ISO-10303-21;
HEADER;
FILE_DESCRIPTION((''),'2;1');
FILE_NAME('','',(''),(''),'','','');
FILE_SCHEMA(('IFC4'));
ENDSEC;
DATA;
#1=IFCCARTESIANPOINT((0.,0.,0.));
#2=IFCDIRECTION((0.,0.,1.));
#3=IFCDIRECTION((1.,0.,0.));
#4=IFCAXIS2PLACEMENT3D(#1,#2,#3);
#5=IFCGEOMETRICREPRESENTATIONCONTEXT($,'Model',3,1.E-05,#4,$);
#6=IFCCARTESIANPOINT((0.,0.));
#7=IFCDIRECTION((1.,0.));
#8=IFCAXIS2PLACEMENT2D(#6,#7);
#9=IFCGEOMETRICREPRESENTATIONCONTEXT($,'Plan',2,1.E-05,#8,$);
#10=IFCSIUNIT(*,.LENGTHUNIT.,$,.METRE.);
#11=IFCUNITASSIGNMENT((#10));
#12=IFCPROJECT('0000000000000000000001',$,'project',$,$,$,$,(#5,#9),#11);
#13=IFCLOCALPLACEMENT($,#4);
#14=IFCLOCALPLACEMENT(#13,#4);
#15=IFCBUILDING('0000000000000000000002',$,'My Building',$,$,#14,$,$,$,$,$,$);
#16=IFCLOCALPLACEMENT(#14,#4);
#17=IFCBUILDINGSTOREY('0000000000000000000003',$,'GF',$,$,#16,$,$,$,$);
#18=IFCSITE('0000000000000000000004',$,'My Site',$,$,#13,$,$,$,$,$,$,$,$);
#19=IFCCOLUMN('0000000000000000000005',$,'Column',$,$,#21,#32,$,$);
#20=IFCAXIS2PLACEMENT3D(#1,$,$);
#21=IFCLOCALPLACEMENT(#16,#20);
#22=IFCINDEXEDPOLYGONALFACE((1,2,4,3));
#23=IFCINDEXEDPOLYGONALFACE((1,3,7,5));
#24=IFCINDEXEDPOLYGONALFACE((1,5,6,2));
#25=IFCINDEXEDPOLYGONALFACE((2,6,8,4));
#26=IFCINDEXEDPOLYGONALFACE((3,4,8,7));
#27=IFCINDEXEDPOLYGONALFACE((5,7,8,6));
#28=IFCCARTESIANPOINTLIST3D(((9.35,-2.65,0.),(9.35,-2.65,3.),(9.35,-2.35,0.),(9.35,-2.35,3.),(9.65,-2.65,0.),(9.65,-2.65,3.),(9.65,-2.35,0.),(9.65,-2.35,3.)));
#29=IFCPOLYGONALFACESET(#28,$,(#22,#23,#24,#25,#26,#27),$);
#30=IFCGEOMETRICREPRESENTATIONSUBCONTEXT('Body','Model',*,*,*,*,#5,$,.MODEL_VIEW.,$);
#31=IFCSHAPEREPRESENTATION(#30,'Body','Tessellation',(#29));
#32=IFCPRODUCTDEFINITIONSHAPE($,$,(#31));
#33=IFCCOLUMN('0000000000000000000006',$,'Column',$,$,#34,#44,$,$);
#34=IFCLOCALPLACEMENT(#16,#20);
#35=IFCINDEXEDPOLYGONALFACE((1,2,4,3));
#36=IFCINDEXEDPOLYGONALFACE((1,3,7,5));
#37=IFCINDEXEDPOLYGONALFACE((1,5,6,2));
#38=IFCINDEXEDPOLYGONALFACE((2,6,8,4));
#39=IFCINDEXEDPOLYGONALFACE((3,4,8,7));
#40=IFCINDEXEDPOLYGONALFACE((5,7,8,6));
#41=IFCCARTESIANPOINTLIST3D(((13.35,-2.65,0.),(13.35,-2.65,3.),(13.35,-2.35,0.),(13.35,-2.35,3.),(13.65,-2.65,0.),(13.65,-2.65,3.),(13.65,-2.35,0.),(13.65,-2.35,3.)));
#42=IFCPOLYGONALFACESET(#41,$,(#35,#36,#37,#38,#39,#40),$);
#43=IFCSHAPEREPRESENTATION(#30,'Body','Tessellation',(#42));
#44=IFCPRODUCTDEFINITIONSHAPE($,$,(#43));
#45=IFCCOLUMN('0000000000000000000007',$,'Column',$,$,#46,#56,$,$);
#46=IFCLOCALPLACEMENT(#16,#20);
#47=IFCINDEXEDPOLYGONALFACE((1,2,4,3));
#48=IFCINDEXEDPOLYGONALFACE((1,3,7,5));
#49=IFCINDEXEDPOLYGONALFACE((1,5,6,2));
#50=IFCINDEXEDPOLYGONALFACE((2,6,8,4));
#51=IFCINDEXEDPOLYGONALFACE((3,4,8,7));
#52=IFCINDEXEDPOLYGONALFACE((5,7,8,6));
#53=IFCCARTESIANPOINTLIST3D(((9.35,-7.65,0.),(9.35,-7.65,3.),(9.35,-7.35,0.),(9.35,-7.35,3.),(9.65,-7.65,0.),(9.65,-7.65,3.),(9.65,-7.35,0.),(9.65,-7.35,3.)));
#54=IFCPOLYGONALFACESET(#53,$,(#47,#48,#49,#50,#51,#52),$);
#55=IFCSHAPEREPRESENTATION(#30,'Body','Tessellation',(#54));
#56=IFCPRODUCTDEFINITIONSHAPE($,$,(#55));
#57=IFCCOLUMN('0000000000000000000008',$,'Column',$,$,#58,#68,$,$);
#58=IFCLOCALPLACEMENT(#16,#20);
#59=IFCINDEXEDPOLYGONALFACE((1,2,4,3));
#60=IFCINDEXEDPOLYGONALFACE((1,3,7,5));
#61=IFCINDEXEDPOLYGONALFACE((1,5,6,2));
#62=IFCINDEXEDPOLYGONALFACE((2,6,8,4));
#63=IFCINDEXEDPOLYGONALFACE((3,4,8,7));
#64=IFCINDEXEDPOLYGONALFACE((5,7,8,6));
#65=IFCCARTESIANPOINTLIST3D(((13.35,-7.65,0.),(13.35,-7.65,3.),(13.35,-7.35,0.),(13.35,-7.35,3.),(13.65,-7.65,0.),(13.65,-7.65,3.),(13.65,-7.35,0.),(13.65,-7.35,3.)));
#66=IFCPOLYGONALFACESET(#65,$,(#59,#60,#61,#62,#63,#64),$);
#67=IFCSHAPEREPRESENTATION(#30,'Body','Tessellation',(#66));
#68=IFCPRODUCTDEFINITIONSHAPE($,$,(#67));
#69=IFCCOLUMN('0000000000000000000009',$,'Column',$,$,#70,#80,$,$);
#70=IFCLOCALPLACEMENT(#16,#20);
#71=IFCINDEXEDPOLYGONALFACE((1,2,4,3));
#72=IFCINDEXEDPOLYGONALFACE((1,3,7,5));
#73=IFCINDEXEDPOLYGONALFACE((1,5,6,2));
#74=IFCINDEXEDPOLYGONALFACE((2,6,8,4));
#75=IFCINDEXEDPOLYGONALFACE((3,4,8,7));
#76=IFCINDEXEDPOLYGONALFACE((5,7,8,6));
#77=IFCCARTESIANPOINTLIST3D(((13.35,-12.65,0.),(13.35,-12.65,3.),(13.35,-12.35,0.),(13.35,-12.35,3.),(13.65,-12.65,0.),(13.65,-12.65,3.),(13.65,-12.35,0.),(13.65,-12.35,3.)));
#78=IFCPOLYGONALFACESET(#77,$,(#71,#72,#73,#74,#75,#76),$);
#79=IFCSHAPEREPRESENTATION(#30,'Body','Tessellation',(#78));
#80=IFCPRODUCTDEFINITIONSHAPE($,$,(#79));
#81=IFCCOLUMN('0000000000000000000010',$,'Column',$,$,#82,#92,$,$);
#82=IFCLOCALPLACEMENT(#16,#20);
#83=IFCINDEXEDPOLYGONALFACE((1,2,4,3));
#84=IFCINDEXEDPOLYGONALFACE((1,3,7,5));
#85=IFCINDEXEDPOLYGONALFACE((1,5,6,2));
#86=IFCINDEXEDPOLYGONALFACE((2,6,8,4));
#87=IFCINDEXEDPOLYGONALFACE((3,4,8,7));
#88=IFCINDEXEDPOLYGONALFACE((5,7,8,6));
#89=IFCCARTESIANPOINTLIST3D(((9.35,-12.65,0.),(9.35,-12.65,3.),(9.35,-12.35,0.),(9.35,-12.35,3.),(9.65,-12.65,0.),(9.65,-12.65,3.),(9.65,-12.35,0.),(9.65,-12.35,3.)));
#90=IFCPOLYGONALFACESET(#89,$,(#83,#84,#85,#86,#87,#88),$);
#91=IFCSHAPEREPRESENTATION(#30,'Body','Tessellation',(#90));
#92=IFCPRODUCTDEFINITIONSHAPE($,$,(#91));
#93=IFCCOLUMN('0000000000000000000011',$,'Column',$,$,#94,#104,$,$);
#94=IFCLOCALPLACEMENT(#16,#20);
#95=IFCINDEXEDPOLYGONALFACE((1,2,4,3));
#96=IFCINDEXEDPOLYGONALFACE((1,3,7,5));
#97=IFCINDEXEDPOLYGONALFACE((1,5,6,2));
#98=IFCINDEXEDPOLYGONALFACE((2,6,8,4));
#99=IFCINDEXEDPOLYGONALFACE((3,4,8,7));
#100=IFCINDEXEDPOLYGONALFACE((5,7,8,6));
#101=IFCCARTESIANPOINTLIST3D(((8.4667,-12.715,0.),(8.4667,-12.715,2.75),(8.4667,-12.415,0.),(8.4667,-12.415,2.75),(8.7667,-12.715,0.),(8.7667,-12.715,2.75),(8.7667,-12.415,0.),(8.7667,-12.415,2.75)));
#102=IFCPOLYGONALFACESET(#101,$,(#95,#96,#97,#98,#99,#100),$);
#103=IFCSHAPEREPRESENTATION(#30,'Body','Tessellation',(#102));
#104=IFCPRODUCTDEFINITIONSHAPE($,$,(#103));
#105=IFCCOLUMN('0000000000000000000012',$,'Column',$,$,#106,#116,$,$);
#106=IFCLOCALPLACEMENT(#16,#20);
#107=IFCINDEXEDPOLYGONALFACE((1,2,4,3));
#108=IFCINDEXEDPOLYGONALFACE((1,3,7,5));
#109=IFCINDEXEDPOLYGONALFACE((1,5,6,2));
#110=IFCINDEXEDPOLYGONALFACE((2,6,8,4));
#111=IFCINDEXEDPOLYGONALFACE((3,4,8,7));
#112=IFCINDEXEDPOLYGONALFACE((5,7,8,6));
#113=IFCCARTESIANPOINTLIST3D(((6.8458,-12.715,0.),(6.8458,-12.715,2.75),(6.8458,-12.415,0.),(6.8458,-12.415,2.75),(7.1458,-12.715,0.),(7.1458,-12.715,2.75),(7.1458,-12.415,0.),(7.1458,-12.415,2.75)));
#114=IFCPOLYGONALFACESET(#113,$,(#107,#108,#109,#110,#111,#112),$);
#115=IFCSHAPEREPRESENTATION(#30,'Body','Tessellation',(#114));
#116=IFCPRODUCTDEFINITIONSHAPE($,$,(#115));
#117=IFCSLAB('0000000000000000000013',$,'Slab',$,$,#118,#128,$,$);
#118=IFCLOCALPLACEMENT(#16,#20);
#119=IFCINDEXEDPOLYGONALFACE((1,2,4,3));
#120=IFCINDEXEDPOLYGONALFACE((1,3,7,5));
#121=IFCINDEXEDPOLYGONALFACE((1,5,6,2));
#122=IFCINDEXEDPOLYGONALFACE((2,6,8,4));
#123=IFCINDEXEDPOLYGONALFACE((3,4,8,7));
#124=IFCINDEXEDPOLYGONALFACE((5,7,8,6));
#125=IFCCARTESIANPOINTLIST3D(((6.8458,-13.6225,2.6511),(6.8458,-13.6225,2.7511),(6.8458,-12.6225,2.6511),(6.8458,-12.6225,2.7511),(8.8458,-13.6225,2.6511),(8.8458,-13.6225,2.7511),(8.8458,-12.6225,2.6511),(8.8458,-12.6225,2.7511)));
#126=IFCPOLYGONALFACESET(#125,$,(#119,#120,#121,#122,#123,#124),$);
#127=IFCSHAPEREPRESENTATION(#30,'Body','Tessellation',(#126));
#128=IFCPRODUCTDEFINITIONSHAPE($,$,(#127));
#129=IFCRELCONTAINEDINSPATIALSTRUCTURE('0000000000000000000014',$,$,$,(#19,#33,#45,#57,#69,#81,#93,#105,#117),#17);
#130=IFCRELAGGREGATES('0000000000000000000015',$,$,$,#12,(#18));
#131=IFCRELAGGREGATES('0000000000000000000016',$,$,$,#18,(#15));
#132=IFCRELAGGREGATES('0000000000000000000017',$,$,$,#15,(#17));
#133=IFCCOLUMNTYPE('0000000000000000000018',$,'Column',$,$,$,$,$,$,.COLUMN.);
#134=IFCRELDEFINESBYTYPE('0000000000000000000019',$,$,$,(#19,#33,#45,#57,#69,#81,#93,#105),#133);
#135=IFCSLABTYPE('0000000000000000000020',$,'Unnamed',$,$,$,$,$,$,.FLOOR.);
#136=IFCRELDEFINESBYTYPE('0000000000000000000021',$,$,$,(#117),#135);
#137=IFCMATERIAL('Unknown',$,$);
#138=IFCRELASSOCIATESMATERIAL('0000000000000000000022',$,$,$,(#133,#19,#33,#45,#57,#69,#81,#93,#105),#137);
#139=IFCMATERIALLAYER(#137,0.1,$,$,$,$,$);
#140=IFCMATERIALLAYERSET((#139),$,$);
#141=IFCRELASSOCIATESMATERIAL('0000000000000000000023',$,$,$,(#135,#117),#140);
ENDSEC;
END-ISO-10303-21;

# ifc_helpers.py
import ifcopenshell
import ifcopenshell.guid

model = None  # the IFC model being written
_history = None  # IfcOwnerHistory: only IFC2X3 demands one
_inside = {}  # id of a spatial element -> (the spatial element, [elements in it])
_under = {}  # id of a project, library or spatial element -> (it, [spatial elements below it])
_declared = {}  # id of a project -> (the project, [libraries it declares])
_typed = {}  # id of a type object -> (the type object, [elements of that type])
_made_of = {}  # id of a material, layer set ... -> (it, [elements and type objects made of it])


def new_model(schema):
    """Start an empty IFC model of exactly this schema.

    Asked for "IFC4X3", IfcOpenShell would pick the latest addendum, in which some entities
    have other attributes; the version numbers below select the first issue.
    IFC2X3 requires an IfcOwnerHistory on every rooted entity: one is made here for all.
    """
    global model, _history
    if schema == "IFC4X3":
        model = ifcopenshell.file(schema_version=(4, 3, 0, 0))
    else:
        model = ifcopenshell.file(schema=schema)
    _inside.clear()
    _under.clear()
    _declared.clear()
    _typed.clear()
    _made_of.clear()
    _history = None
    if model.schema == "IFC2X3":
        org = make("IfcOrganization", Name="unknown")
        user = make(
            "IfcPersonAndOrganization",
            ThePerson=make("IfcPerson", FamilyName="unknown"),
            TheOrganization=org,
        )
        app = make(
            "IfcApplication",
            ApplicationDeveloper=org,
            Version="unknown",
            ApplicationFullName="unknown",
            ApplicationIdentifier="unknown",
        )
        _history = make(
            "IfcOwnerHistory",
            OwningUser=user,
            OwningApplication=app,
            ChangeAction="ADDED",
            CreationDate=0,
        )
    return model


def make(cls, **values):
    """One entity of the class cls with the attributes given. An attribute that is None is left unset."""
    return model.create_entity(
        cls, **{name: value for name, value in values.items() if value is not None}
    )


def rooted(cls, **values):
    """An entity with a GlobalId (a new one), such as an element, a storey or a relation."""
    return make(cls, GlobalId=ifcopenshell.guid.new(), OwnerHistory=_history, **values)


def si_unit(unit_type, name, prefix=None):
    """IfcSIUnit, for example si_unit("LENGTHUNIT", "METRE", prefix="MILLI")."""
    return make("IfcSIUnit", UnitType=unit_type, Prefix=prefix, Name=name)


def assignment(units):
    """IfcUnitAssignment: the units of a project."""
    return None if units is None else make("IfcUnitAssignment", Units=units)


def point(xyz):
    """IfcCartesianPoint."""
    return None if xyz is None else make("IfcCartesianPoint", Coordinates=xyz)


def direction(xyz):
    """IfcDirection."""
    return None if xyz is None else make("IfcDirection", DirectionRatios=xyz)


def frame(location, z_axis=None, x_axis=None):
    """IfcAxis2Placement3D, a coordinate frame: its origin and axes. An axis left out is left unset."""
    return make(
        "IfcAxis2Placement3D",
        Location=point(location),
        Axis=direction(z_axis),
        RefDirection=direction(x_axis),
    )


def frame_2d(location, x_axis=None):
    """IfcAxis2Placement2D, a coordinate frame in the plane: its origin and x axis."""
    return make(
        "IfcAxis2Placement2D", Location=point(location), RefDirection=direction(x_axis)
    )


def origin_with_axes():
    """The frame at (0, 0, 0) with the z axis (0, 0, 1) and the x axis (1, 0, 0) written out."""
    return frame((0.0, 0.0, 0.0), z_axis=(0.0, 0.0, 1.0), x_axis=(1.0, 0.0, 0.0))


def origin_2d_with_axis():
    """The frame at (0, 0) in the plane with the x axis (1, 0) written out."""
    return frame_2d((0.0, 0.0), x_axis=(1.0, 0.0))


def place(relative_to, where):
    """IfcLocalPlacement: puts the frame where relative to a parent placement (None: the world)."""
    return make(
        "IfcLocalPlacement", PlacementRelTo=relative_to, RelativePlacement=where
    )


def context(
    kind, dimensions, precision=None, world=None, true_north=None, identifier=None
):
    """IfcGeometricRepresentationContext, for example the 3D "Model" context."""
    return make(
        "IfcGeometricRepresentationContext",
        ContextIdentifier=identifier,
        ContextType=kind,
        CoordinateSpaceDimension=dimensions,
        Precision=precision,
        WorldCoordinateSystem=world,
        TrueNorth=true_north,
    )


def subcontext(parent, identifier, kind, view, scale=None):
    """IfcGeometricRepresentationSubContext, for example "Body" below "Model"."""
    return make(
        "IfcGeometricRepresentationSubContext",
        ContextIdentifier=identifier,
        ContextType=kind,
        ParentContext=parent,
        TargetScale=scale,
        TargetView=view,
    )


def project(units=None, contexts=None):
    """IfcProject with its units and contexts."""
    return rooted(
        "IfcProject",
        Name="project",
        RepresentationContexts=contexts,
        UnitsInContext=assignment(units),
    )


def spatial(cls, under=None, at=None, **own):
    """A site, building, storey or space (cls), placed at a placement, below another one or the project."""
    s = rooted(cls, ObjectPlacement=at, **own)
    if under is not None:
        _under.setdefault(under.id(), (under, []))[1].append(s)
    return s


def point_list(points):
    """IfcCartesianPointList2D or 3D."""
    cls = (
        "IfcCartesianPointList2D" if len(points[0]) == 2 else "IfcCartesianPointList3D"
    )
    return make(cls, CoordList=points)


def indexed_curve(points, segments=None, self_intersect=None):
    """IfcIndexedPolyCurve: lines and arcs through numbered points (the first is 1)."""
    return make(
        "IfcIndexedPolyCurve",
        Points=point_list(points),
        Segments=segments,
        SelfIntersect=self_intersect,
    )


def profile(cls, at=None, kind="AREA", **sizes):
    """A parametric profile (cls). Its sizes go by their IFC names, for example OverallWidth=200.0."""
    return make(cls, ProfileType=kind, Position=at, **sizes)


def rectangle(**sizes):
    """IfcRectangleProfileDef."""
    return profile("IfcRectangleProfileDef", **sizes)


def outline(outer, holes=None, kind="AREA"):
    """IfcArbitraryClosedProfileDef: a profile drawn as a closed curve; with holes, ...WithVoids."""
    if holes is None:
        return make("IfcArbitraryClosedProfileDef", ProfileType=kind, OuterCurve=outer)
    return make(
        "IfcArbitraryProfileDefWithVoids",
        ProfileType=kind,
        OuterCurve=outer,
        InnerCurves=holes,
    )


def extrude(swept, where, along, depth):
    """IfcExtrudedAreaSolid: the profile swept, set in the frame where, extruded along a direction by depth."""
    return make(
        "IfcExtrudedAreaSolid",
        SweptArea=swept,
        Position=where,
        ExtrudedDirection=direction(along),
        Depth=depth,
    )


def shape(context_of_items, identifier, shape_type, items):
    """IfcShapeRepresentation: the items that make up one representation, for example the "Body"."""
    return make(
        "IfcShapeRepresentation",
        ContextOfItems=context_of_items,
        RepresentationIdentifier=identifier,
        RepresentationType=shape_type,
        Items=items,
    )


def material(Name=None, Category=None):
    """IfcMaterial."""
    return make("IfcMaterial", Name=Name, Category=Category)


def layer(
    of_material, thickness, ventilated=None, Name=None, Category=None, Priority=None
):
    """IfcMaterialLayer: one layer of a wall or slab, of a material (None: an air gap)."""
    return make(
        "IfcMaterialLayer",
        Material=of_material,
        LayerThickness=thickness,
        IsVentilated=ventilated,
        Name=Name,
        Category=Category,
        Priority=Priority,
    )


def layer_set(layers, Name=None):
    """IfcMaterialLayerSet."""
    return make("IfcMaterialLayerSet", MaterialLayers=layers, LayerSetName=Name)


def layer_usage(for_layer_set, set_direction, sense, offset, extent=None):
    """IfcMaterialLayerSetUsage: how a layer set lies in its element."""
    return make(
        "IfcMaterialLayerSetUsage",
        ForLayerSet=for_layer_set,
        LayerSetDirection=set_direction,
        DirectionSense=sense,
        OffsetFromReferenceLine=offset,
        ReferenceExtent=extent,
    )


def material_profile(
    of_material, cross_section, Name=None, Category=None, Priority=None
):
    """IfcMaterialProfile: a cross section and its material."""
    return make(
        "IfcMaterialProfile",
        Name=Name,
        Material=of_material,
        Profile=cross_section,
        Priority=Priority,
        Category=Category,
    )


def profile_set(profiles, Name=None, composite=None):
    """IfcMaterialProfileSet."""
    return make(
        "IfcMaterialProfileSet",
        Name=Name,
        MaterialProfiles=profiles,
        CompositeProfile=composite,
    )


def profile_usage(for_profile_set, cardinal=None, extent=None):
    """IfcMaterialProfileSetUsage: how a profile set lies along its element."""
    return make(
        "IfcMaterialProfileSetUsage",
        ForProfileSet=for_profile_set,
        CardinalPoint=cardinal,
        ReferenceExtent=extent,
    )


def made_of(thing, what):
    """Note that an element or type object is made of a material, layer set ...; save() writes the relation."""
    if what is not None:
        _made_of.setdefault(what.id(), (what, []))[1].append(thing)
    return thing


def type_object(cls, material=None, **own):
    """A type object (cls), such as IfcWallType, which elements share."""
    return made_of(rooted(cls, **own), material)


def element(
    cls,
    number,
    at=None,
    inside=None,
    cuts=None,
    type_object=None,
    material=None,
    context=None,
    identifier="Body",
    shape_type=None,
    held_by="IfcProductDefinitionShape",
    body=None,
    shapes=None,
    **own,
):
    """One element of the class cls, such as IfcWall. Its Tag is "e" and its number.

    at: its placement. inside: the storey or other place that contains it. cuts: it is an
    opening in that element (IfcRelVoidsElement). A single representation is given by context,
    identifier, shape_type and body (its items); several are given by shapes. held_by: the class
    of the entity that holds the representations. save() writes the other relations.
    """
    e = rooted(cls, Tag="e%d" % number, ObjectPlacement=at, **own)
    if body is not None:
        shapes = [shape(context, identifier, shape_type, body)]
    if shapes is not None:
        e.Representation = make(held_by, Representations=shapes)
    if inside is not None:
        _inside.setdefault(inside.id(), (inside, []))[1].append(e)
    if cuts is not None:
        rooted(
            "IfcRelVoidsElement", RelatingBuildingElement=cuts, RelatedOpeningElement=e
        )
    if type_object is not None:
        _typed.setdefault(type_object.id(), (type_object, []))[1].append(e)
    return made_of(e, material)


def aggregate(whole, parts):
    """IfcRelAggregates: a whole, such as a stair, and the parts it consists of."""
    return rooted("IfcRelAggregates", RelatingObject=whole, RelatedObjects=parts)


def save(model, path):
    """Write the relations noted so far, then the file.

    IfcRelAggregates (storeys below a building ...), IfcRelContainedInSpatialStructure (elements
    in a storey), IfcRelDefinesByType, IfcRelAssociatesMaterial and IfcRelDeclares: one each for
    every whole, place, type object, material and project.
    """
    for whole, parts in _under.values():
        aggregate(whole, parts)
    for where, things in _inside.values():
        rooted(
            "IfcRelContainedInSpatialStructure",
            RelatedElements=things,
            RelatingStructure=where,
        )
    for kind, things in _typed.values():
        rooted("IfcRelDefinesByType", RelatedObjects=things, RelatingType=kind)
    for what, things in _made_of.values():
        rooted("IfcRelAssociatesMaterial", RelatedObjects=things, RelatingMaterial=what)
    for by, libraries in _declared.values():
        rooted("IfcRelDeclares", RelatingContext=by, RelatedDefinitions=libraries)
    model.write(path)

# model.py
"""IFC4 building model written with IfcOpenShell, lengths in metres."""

from ifc_helpers import new_model, si_unit, frame, origin_with_axes, origin_2d_with_axis, place, context, subcontext, project, spatial, indexed_curve, rectangle, outline, extrude, material, layer, layer_set, layer_usage, material_profile, profile_set, profile_usage, type_object, element, save


model = new_model("IFC4")

# Units and contexts
model_context = context("Model", 3, precision=1e-05, world=origin_with_axes())
plan_context = context("Plan", 2, precision=1e-05, world=origin_2d_with_axis())
body_context_1 = subcontext(model_context, "Body", "Model", "MODEL_VIEW")
ifc_project = project(units=[si_unit("LENGTHUNIT", "METRE")], contexts=[model_context, plan_context])

# Site, building, storey
site_placement = place(None, origin_with_axes())
site = spatial("IfcSite", under=ifc_project, at=site_placement, Name="My Site")
building_placement = place(site_placement, origin_with_axes())
building = spatial("IfcBuilding", under=site, at=building_placement, Name="My Building")
storey_placement = place(building_placement, origin_with_axes())
storey = spatial("IfcBuildingStorey", under=building, at=storey_placement, Name="GF")

# Columns
ifc_material_1 = material(Name="Unknown")
ifc_material_profile_1 = material_profile(ifc_material_1, rectangle(XDim=0.3, YDim=0.3))
ifc_profile_set_1 = profile_set([ifc_material_profile_1])
ifc_profile_usage_1 = profile_usage(ifc_profile_set_1, cardinal=5)
column_type = type_object("IfcColumnType", Name="Column", PredefinedType="COLUMN", material=ifc_profile_set_1)
column_1_placement = place(storey_placement, frame((9.5, -2.5, 0.0), z_axis=(0.0, 0.0, 1.0), x_axis=(1.0, 0.0, 0.0)))
element("IfcColumn", 1, at=column_1_placement, inside=storey, type_object=column_type, material=ifc_profile_usage_1, Name="Column", context=body_context_1, shape_type="SweptSolid", body=[
    extrude(rectangle(XDim=0.3, YDim=0.3), origin_with_axes(), (0.0, 0.0, 1.0), 3.0),
])
ifc_profile_usage_2 = profile_usage(ifc_profile_set_1, cardinal=5)
column_2_placement = place(storey_placement, frame((13.5, -2.5, 0.0), z_axis=(0.0, 0.0, 1.0), x_axis=(1.0, 0.0, 0.0)))
element("IfcColumn", 2, at=column_2_placement, inside=storey, type_object=column_type, material=ifc_profile_usage_2, Name="Column", context=body_context_1, shape_type="SweptSolid", body=[
    extrude(rectangle(XDim=0.3, YDim=0.3), origin_with_axes(), (0.0, 0.0, 1.0), 3.0),
])
ifc_profile_usage_3 = profile_usage(ifc_profile_set_1, cardinal=5)
column_3_placement = place(storey_placement, frame((9.5, -7.5, 0.0), z_axis=(0.0, 0.0, 1.0), x_axis=(1.0, 0.0, 0.0)))
element("IfcColumn", 3, at=column_3_placement, inside=storey, type_object=column_type, material=ifc_profile_usage_3, Name="Column", context=body_context_1, shape_type="SweptSolid", body=[
    extrude(rectangle(XDim=0.3, YDim=0.3), origin_with_axes(), (0.0, 0.0, 1.0), 3.0),
])
ifc_profile_usage_4 = profile_usage(ifc_profile_set_1, cardinal=5)
column_4_placement = place(storey_placement, frame((13.5, -7.5, 0.0), z_axis=(0.0, 0.0, 1.0), x_axis=(1.0, 0.0, 0.0)))
element("IfcColumn", 4, at=column_4_placement, inside=storey, type_object=column_type, material=ifc_profile_usage_4, Name="Column", context=body_context_1, shape_type="SweptSolid", body=[
    extrude(rectangle(XDim=0.3, YDim=0.3), origin_with_axes(), (0.0, 0.0, 1.0), 3.0),
])
ifc_profile_usage_5 = profile_usage(ifc_profile_set_1, cardinal=5)
column_5_placement = place(storey_placement, frame((13.5, -12.5, 0.0), z_axis=(0.0, 0.0, 1.0), x_axis=(1.0, 0.0, 0.0)))
element("IfcColumn", 5, at=column_5_placement, inside=storey, type_object=column_type, material=ifc_profile_usage_5, Name="Column", context=body_context_1, shape_type="SweptSolid", body=[
    extrude(rectangle(XDim=0.3, YDim=0.3), origin_with_axes(), (0.0, 0.0, 1.0), 3.0),
])
ifc_profile_usage_6 = profile_usage(ifc_profile_set_1, cardinal=5)
column_6_placement = place(storey_placement, frame((9.5, -12.5, 0.0), z_axis=(0.0, 0.0, 1.0), x_axis=(1.0, 0.0, 0.0)))
element("IfcColumn", 6, at=column_6_placement, inside=storey, type_object=column_type, material=ifc_profile_usage_6, Name="Column", context=body_context_1, shape_type="SweptSolid", body=[
    extrude(rectangle(XDim=0.3, YDim=0.3), origin_with_axes(), (0.0, 0.0, 1.0), 3.0),
])
ifc_profile_usage_7 = profile_usage(ifc_profile_set_1, cardinal=4)
column_7_placement = place(storey_placement, frame((8.7667, -12.565, 0.0), z_axis=(0.0, 0.0, 1.0), x_axis=(1.0, 0.0, 0.0)))
element("IfcColumn", 7, at=column_7_placement, inside=storey, type_object=column_type, material=ifc_profile_usage_7, Name="Column", context=body_context_1, shape_type="SweptSolid", body=[
    extrude(rectangle(XDim=0.3, YDim=0.3), frame((-0.15, 0.0, 0.0), z_axis=(0.0, 0.0, 1.0), x_axis=(1.0, 0.0, 0.0)), (0.0, 0.0, 1.0), 2.75),
])
ifc_profile_usage_8 = profile_usage(ifc_profile_set_1, cardinal=4)
column_8_placement = place(storey_placement, frame((7.1458, -12.565, 0.0), z_axis=(0.0, 0.0, 1.0), x_axis=(1.0, 0.0, 0.0)))
element("IfcColumn", 8, at=column_8_placement, inside=storey, type_object=column_type, material=ifc_profile_usage_8, Name="Column", context=body_context_1, shape_type="SweptSolid", body=[
    extrude(rectangle(XDim=0.3, YDim=0.3), frame((-0.15, 0.0, 0.0), z_axis=(0.0, 0.0, 1.0), x_axis=(1.0, 0.0, 0.0)), (0.0, 0.0, 1.0), 2.75),
])

# Slab
ifc_layer_1 = layer(ifc_material_1, 0.1)
ifc_layer_set_1 = layer_set([ifc_layer_1])
ifc_layer_usage_1 = layer_usage(ifc_layer_set_1, "AXIS3", "POSITIVE", -0.1)
slab_type = type_object("IfcSlabType", Name="Unnamed", PredefinedType="FLOOR", material=ifc_layer_set_1)
slab_placement = place(storey_placement, frame((6.8458, -12.6225, 2.7511), z_axis=(0.0, 0.0, 1.0), x_axis=(1.0, 0.0, 0.0)))
element("IfcSlab", 9, at=slab_placement, inside=storey, type_object=slab_type, material=ifc_layer_usage_1, Name="Slab", context=body_context_1, shape_type="SweptSolid", body=[
    extrude(outline(indexed_curve([(0.0, 0.0), (2.0, 0.0), (2.0, -1.0), (0.0, -1.0), (0.0, 0.0)])), frame((0.0, 0.0, -0.1), z_axis=(0.0, 0.0, 1.0), x_axis=(1.0, 0.0, 0.0)), (0.0, 0.0, 1.0), 0.1),
])

save(model, "model.ifc")
